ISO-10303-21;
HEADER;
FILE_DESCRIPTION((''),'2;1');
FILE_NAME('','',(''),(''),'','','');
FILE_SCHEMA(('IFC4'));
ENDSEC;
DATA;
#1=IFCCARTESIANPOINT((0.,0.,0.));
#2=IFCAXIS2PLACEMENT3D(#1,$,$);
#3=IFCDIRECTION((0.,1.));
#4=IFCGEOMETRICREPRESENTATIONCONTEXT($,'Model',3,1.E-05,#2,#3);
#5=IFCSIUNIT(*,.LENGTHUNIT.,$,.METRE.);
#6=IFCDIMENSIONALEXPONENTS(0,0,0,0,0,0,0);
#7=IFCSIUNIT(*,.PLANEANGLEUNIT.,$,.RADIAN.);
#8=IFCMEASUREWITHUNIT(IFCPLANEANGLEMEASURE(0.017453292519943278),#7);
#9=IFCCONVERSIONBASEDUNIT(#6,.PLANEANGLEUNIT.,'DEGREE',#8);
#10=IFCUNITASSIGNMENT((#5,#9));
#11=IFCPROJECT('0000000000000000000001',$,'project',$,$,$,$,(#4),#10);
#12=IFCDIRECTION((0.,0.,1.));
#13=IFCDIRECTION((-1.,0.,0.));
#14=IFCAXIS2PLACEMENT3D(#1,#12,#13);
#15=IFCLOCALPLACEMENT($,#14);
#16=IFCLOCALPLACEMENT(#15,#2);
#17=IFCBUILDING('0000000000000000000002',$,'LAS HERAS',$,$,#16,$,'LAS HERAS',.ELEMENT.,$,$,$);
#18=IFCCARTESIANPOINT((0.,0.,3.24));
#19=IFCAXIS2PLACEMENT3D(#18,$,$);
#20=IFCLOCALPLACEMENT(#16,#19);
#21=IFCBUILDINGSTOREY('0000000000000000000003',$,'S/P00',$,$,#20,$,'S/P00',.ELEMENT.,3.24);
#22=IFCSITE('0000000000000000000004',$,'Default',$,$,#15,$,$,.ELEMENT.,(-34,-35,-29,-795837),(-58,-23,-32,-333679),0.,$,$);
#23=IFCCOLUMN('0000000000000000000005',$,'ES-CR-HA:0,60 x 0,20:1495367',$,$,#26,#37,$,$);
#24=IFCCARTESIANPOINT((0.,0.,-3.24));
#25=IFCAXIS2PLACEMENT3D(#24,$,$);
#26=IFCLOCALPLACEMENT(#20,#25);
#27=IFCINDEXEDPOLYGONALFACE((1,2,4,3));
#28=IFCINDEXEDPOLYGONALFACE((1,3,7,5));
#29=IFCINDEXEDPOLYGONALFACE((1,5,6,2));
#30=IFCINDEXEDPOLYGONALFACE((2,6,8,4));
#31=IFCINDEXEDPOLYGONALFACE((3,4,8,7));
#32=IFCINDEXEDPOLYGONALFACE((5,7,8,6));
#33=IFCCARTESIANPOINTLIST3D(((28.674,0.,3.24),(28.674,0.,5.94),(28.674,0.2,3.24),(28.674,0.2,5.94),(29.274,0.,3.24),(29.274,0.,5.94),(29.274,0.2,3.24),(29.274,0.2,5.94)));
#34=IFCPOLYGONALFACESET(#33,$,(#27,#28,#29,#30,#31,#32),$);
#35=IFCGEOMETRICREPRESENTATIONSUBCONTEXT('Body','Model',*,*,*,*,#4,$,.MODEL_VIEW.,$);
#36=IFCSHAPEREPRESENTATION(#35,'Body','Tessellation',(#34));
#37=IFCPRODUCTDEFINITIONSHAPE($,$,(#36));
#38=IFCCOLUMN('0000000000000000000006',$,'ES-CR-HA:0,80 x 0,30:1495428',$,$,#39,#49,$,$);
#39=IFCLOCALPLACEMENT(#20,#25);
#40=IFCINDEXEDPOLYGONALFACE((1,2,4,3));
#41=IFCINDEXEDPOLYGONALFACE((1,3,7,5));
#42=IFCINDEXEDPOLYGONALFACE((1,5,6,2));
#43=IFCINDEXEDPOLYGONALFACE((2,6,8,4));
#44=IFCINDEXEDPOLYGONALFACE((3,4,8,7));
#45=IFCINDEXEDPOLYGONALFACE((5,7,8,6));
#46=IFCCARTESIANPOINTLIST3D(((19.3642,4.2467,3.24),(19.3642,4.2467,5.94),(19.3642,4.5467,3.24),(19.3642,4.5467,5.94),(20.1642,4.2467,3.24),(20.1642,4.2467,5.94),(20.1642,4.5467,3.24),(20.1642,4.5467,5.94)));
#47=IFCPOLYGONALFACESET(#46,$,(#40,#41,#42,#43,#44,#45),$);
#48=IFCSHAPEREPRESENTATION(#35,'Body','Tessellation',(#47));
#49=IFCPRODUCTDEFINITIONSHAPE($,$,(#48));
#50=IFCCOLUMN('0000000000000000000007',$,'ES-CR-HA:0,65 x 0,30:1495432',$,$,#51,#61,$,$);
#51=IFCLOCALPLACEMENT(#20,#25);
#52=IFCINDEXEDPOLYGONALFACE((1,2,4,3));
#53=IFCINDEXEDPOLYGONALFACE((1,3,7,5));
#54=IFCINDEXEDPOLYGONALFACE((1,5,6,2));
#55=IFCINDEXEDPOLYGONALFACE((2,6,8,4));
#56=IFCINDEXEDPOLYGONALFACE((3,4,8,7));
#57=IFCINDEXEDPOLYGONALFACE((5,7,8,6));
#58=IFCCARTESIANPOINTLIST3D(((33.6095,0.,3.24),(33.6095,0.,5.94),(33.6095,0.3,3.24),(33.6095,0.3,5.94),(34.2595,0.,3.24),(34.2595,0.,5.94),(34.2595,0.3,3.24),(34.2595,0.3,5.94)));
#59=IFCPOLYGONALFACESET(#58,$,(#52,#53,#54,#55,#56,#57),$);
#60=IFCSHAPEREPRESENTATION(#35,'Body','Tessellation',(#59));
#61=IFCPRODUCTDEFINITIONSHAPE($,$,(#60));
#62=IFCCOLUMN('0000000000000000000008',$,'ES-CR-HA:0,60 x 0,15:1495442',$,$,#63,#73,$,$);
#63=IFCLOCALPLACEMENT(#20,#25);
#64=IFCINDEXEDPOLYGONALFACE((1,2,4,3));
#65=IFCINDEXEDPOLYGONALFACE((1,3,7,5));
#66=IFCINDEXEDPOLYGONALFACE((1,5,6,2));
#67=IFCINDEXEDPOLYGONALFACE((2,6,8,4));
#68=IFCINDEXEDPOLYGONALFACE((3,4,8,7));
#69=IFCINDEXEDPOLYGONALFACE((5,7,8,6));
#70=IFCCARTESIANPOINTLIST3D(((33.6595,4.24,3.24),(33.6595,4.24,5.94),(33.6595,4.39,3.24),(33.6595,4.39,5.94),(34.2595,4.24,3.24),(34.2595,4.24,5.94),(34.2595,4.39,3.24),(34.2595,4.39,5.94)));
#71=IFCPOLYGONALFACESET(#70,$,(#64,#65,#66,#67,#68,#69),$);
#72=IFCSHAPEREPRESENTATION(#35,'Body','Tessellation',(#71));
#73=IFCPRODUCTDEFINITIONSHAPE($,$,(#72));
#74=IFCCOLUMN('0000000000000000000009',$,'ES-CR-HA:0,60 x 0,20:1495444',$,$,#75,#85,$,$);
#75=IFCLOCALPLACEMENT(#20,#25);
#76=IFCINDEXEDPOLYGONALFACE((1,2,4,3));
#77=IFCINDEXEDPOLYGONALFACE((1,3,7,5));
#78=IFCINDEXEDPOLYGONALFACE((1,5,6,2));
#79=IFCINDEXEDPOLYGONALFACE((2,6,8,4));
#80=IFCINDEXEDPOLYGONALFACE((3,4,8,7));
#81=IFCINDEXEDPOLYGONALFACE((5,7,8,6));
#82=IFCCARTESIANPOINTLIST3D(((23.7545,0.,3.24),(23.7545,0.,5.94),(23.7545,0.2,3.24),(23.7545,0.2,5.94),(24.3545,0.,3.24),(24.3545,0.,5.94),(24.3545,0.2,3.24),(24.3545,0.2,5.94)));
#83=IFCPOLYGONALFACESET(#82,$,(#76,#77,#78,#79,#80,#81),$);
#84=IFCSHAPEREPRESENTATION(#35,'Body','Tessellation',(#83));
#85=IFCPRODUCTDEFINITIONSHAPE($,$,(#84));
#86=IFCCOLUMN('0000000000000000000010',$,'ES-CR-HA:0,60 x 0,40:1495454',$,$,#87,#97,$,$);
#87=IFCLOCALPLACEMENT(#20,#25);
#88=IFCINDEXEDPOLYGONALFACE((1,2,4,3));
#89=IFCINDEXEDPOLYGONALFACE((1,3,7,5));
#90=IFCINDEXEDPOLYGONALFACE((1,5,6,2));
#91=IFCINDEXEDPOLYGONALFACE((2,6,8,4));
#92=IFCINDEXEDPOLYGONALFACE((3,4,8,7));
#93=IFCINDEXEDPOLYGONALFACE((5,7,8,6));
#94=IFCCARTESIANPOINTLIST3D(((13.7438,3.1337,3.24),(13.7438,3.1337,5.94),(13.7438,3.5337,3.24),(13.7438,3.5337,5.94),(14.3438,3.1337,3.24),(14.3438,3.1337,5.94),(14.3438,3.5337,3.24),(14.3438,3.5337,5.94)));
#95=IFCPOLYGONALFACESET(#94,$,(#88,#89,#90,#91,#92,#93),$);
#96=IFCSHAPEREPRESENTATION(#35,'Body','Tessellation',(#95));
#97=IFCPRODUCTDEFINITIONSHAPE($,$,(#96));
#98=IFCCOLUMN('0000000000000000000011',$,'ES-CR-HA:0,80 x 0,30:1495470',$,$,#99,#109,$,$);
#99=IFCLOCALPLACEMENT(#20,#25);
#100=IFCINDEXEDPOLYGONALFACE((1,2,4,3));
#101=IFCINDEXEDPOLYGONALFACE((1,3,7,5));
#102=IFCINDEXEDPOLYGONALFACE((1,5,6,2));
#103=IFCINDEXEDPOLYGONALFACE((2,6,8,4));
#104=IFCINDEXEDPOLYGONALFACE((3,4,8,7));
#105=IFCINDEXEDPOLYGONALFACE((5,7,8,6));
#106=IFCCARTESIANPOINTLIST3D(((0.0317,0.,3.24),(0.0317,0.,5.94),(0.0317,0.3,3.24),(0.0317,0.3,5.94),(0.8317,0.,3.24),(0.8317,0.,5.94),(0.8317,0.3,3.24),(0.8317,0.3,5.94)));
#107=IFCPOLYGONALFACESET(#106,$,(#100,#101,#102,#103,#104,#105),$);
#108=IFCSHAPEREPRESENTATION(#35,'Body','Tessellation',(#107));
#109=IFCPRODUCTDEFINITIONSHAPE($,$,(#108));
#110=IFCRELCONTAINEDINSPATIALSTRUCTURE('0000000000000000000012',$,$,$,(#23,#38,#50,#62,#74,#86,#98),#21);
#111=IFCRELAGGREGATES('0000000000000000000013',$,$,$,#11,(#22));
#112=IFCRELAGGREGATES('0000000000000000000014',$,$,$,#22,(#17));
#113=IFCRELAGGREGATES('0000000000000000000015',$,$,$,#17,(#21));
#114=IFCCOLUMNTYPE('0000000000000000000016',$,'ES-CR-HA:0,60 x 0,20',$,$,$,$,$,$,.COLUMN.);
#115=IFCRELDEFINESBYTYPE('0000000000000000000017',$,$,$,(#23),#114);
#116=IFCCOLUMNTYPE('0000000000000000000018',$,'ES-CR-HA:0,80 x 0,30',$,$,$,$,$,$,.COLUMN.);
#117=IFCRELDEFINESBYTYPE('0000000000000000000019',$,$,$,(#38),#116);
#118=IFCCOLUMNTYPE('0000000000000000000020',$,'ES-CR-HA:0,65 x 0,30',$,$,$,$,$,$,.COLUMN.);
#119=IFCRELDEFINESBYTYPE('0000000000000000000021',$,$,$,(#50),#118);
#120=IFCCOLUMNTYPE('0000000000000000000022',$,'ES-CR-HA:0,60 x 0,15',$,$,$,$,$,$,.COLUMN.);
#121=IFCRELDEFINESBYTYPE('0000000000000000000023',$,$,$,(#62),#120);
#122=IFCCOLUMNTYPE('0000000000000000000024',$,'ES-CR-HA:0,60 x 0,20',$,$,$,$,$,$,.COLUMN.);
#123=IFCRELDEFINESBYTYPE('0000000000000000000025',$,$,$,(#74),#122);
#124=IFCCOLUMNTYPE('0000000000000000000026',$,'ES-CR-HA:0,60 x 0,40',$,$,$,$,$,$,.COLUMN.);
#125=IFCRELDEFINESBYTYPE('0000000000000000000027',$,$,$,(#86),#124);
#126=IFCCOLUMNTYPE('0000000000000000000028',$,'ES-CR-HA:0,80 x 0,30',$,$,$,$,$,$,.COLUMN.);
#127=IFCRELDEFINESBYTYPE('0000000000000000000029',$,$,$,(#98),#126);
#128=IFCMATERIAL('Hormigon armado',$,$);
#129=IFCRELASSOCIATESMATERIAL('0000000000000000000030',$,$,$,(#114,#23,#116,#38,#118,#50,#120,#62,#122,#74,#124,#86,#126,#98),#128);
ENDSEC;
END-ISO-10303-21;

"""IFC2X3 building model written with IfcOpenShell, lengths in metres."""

from ifc_helpers import new_model, entity, si_unit, converted_unit, direction, frame, frame_2d, origin, place, context, subcontext, project, spatial, rectangle, extrude, source, transform, mapped, material, type_object, type_shapes, element, save


model = new_model("IFC2X3")

# Units and contexts
model_context = context("Model", 3, precision=1e-05, world=origin(), true_north=direction((0.0, 1.0)))
body_context = subcontext(model_context, "Body", "Model", "MODEL_VIEW")
ifc_project = project(units=[si_unit("LENGTHUNIT", "METRE"), converted_unit("PLANEANGLEUNIT", "DEGREE", entity("IfcPlaneAngleMeasure", 0.017453292519943278), si_unit("PLANEANGLEUNIT", "RADIAN"), dimensions=[0, 0, 0, 0, 0, 0, 0])], contexts=[model_context])

# Site, building, storey
site_placement = place(None, frame((0.0, 0.0, 0.0), z_axis=(0.0, 0.0, 1.0), x_axis=(-1.0, 0.0, 0.0)))
site = spatial("IfcSite", under=ifc_project, at=site_placement, Name="Default", CompositionType="ELEMENT", RefLatitude=(-34, -35, -29, -795837), RefLongitude=(-58, -23, -32, -333679), RefElevation=0.0)
building_placement = place(site_placement, origin())
building = spatial("IfcBuilding", under=site, at=building_placement, Name="LAS HERAS", LongName="LAS HERAS", CompositionType="ELEMENT")
storey_placement = place(building_placement, frame((0.0, 0.0, 3.24)))
storey = spatial("IfcBuildingStorey", under=building, at=storey_placement, Name="S/P00", LongName="S/P00", CompositionType="ELEMENT", Elevation=3.24)

# Columns
ifc_material = material(Name="Hormigon armado")
column_type_1 = type_object("IfcColumnType", Name="ES-CR-HA:0,60 x 0,20", PredefinedType="COLUMN", material=ifc_material)
shared_shape_1 = source(origin(), body_context, "Body", "SweptSolid", [
    extrude(rectangle(XDim=2.7, YDim=0.2, at=frame_2d((0.0, 0.0), x_axis=(1.0, 0.0))), frame((28.674, 0.1, 4.59), z_axis=(1.0, 0.0, 0.0), x_axis=(0.0, 0.0, 1.0)), (0.0, 0.0, 1.0), 0.6),
])
type_shapes(column_type_1, [shared_shape_1])
column_1_placement = place(storey_placement, frame((0.0, 0.0, -3.24)))
element("IfcColumn", 1, at=column_1_placement, inside=storey, type_object=column_type_1, material=ifc_material, Name="ES-CR-HA:0,60 x 0,20:1495367", context=body_context, shape_type="MappedRepresentation", body=[
    mapped(shared_shape_1, transform((0.0, 0.0, 0.0), scale=1.0)),
])
column_type_2 = type_object("IfcColumnType", Name="ES-CR-HA:0,80 x 0,30", PredefinedType="COLUMN", material=ifc_material)
shared_shape_2 = source(origin(), body_context, "Body", "SweptSolid", [
    extrude(rectangle(XDim=2.7, YDim=0.3, at=frame_2d((0.0, 0.0), x_axis=(1.0, 0.0))), frame((19.3642, 4.3967, 4.59), z_axis=(1.0, 0.0, 0.0), x_axis=(0.0, 0.0, 1.0)), (0.0, 0.0, 1.0), 0.8),
])
type_shapes(column_type_2, [shared_shape_2])
column_2_placement = place(storey_placement, frame((0.0, 0.0, -3.24)))
element("IfcColumn", 2, at=column_2_placement, inside=storey, type_object=column_type_2, material=ifc_material, Name="ES-CR-HA:0,80 x 0,30:1495428", context=body_context, shape_type="MappedRepresentation", body=[
    mapped(shared_shape_2, transform((0.0, 0.0, 0.0), scale=1.0)),
])
column_type_3 = type_object("IfcColumnType", Name="ES-CR-HA:0,65 x 0,30", PredefinedType="COLUMN", material=ifc_material)
shared_shape_3 = source(origin(), body_context, "Body", "SweptSolid", [
    extrude(rectangle(XDim=2.7, YDim=0.3, at=frame_2d((0.0, 0.0), x_axis=(1.0, 0.0))), frame((33.6095, 0.15, 4.59), z_axis=(1.0, 0.0, 0.0), x_axis=(0.0, 0.0, 1.0)), (0.0, 0.0, 1.0), 0.65),
])
type_shapes(column_type_3, [shared_shape_3])
column_3_placement = place(storey_placement, frame((0.0, 0.0, -3.24)))
element("IfcColumn", 3, at=column_3_placement, inside=storey, type_object=column_type_3, material=ifc_material, Name="ES-CR-HA:0,65 x 0,30:1495432", context=body_context, shape_type="MappedRepresentation", body=[
    mapped(shared_shape_3, transform((0.0, 0.0, 0.0), scale=1.0)),
])
column_type_4 = type_object("IfcColumnType", Name="ES-CR-HA:0,60 x 0,15", PredefinedType="COLUMN", material=ifc_material)
shared_shape_4 = source(origin(), body_context, "Body", "SweptSolid", [
    extrude(rectangle(XDim=2.7, YDim=0.15, at=frame_2d((0.0, 0.0), x_axis=(1.0, 0.0))), frame((33.6595, 4.315, 4.59), z_axis=(1.0, 0.0, 0.0), x_axis=(0.0, 0.0, 1.0)), (0.0, 0.0, 1.0), 0.6),
])
type_shapes(column_type_4, [shared_shape_4])
column_4_placement = place(storey_placement, frame((0.0, 0.0, -3.24)))
element("IfcColumn", 4, at=column_4_placement, inside=storey, type_object=column_type_4, material=ifc_material, Name="ES-CR-HA:0,60 x 0,15:1495442", context=body_context, shape_type="MappedRepresentation", body=[
    mapped(shared_shape_4, transform((0.0, 0.0, 0.0), scale=1.0)),
])
column_type_5 = type_object("IfcColumnType", Name="ES-CR-HA:0,60 x 0,20", PredefinedType="COLUMN", material=ifc_material)
shared_shape_5 = source(origin(), body_context, "Body", "SweptSolid", [
    extrude(rectangle(XDim=2.7, YDim=0.2, at=frame_2d((0.0, 0.0), x_axis=(1.0, 0.0))), frame((23.7545, 0.1, 4.59), z_axis=(1.0, 0.0, 0.0), x_axis=(0.0, 0.0, 1.0)), (0.0, 0.0, 1.0), 0.6),
])
type_shapes(column_type_5, [shared_shape_5])
column_5_placement = place(storey_placement, frame((0.0, 0.0, -3.24)))
element("IfcColumn", 5, at=column_5_placement, inside=storey, type_object=column_type_5, material=ifc_material, Name="ES-CR-HA:0,60 x 0,20:1495444", context=body_context, shape_type="MappedRepresentation", body=[
    mapped(shared_shape_5, transform((0.0, 0.0, 0.0), scale=1.0)),
])
column_type_6 = type_object("IfcColumnType", Name="ES-CR-HA:0,60 x 0,40", PredefinedType="COLUMN", material=ifc_material)
shared_shape_6 = source(origin(), body_context, "Body", "SweptSolid", [
    extrude(rectangle(XDim=2.7, YDim=0.4, at=frame_2d((0.0, 0.0), x_axis=(1.0, 0.0))), frame((13.7438, 3.3337, 4.59), z_axis=(1.0, 0.0, 0.0), x_axis=(0.0, 0.0, 1.0)), (0.0, 0.0, 1.0), 0.6),
])
type_shapes(column_type_6, [shared_shape_6])
column_6_placement = place(storey_placement, frame((0.0, 0.0, -3.24)))
element("IfcColumn", 6, at=column_6_placement, inside=storey, type_object=column_type_6, material=ifc_material, Name="ES-CR-HA:0,60 x 0,40:1495454", context=body_context, shape_type="MappedRepresentation", body=[
    mapped(shared_shape_6, transform((0.0, 0.0, 0.0), scale=1.0)),
])
column_type_7 = type_object("IfcColumnType", Name="ES-CR-HA:0,80 x 0,30", PredefinedType="COLUMN", material=ifc_material)
shared_shape_7 = source(origin(), body_context, "Body", "SweptSolid", [
    extrude(rectangle(XDim=2.7, YDim=0.3, at=frame_2d((0.0, 0.0), x_axis=(1.0, 0.0))), frame((0.0317, 0.15, 4.59), z_axis=(1.0, 0.0, 0.0), x_axis=(0.0, 0.0, 1.0)), (0.0, 0.0, 1.0), 0.8),
])
type_shapes(column_type_7, [shared_shape_7])
column_7_placement = place(storey_placement, frame((0.0, 0.0, -3.24)))
element("IfcColumn", 7, at=column_7_placement, inside=storey, type_object=column_type_7, material=ifc_material, Name="ES-CR-HA:0,80 x 0,30:1495470", context=body_context, shape_type="MappedRepresentation", body=[
    mapped(shared_shape_7, transform((0.0, 0.0, 0.0), scale=1.0)),
])

save(model, "model.ifc")
